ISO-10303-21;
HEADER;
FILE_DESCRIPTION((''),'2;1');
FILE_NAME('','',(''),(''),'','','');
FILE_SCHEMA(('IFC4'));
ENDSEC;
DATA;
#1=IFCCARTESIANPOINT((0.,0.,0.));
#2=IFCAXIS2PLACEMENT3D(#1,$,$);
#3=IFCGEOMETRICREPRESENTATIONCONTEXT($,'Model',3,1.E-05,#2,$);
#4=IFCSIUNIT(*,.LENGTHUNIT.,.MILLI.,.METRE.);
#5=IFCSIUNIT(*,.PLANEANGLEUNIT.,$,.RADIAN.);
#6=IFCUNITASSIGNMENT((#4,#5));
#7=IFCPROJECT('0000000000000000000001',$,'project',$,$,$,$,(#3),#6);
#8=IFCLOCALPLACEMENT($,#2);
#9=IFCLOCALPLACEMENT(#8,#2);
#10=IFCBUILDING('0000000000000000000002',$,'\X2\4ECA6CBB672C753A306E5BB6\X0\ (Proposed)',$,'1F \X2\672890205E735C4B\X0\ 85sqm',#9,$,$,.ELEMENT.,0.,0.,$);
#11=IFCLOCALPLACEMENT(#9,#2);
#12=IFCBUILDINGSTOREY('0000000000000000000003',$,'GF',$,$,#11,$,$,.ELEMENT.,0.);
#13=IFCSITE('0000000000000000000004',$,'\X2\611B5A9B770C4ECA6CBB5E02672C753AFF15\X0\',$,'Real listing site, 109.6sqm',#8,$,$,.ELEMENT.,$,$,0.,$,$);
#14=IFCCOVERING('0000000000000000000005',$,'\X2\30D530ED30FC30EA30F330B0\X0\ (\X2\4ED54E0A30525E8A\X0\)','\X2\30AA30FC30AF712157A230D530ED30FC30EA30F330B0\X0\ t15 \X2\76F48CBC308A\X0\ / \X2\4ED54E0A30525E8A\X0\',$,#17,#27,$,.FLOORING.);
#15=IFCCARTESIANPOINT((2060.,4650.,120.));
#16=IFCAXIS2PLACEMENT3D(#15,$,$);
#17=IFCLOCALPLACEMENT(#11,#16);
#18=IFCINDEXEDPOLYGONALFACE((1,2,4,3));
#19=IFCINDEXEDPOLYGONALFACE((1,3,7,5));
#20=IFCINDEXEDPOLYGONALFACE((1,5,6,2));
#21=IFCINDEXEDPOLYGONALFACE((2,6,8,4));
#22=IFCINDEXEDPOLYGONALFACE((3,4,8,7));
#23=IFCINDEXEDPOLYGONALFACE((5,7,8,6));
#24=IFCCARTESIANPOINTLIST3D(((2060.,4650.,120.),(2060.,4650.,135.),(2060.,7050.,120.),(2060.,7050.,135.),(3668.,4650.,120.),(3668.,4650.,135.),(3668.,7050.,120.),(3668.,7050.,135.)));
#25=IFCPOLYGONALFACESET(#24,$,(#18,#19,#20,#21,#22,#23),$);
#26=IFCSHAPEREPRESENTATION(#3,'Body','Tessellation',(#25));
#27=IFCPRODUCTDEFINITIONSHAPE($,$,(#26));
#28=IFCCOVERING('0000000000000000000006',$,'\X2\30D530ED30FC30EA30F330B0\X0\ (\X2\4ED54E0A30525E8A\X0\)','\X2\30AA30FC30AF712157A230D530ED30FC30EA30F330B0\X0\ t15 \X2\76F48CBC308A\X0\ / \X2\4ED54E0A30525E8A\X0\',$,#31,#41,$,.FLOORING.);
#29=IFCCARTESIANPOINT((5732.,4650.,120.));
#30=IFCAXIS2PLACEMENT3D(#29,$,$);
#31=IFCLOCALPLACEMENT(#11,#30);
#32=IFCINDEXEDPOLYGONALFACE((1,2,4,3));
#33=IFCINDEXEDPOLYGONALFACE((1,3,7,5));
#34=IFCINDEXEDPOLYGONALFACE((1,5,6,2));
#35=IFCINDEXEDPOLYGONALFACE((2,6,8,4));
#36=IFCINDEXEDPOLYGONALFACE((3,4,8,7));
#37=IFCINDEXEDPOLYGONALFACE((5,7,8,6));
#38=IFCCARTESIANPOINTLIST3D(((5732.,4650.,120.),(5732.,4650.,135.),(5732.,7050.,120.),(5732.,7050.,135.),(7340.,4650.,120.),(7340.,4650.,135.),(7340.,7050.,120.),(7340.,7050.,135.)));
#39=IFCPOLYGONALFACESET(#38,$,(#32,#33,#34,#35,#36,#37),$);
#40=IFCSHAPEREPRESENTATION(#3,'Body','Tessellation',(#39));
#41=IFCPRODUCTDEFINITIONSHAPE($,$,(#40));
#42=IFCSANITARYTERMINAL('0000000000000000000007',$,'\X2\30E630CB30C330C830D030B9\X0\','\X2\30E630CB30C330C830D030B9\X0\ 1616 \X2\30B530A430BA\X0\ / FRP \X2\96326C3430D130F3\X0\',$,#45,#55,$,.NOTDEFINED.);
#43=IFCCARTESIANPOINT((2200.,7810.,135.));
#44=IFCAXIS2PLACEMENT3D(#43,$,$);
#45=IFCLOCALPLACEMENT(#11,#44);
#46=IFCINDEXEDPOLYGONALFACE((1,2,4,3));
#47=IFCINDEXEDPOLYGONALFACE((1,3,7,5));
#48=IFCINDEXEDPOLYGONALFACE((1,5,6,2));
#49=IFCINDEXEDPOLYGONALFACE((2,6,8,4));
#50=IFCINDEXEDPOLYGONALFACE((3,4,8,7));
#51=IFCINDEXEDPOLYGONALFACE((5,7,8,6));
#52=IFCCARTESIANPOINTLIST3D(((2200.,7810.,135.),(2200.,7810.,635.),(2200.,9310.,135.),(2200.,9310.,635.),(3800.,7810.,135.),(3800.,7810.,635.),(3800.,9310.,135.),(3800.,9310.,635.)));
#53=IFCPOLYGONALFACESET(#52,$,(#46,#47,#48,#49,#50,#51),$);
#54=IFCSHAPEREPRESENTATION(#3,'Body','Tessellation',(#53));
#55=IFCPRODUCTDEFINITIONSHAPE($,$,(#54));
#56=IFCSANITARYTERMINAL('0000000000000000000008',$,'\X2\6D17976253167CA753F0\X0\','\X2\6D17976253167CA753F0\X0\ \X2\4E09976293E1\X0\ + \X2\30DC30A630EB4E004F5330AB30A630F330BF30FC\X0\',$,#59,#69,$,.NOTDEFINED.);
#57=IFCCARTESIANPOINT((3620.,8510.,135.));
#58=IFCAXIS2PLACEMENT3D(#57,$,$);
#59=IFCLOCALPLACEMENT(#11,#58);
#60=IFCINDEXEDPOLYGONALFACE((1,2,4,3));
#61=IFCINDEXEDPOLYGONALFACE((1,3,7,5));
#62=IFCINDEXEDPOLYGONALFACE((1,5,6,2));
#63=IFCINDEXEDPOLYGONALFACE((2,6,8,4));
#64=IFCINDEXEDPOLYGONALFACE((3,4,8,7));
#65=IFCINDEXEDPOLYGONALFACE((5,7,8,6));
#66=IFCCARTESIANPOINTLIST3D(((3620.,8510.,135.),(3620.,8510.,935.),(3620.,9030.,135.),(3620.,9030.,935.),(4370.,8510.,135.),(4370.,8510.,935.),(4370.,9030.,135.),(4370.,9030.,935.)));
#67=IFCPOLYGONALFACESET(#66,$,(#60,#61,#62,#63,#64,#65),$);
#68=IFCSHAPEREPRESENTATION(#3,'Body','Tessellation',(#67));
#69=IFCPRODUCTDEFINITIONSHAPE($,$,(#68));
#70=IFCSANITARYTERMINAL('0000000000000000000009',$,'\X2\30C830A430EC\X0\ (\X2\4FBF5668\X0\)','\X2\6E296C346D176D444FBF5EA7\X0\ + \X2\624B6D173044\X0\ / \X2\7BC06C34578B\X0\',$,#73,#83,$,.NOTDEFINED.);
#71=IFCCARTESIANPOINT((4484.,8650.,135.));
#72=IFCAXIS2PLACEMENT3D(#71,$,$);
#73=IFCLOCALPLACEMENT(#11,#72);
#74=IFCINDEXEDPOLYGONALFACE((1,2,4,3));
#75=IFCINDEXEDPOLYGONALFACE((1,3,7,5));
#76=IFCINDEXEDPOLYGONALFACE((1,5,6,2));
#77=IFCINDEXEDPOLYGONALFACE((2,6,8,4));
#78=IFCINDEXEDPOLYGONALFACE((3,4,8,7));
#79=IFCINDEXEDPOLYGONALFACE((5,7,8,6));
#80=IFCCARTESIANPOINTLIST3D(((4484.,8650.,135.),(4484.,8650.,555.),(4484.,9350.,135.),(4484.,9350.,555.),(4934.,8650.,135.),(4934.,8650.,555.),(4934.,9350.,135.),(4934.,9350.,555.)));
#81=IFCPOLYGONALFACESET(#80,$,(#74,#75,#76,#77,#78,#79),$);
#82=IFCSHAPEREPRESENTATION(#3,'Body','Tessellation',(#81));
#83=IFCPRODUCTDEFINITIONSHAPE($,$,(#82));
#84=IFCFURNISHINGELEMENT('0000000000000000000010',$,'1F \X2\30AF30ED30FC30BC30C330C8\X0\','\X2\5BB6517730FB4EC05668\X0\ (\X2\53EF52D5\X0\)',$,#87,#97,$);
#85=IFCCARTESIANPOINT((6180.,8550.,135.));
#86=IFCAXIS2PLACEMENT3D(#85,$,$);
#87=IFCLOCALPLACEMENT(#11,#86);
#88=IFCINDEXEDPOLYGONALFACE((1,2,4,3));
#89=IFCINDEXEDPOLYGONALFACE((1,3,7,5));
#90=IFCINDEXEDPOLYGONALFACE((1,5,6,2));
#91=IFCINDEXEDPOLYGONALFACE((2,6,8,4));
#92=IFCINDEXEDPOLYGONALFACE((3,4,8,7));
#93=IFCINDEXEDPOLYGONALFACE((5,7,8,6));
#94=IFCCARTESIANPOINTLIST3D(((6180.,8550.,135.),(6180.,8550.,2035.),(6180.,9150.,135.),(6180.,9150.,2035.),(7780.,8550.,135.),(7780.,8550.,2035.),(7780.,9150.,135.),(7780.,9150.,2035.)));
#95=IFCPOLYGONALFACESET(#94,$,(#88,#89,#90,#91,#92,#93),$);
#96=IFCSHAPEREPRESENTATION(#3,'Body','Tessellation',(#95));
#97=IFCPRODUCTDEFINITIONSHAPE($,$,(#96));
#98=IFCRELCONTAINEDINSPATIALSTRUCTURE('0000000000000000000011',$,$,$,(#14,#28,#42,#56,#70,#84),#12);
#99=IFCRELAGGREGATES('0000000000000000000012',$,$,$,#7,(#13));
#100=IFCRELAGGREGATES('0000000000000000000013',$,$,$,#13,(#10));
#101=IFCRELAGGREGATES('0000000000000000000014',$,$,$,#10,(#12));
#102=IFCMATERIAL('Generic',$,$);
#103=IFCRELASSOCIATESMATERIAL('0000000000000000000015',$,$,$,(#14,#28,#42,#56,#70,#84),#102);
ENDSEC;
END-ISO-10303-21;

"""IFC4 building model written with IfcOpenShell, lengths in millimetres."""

from ifc_helpers import new_model, si_unit, frame, frame_2d, origin, place, context, project, spatial, rectangle, extrude, material, element, save


model = new_model("IFC4")

# Units and contexts
model_context = context("Model", 3, precision=1e-05, world=origin())
ifc_project = project(units=[si_unit("LENGTHUNIT", "METRE", prefix="MILLI"), si_unit("PLANEANGLEUNIT", "RADIAN")], contexts=[model_context])

# Site, building, storey
site_placement = place(None, origin())
site = spatial("IfcSite", under=ifc_project, at=site_placement, Name="愛媛県今治市本町５", ObjectType="Real listing site, 109.6sqm", CompositionType="ELEMENT", RefElevation=0.0)
building_placement = place(site_placement, origin())
building = spatial("IfcBuilding", under=site, at=building_placement, Name="今治本町の家 (Proposed)", ObjectType="1F 木造平屋 85sqm", CompositionType="ELEMENT", ElevationOfRefHeight=0.0, ElevationOfTerrain=0.0)
storey_placement = place(building_placement, origin())
storey = spatial("IfcBuildingStorey", under=building, at=storey_placement, Name="GF", CompositionType="ELEMENT", Elevation=0.0)

# Coverings
ifc_material_1 = material(Name="Generic")
covering_1_placement = place(storey_placement, frame((2060.0, 4650.0, 120.0)))
element("IfcCovering", 1, at=covering_1_placement, inside=storey, material=ifc_material_1, Name="フローリング (仕上げ床)", Description="オーク無垢フローリング t15 直貼り / 仕上げ床", PredefinedType="FLOORING", context=model_context, shape_type="SweptSolid", body=[
    extrude(rectangle(XDim=1608.0, YDim=2400.0, at=frame_2d((804.0, 1200.0))), frame((2060.0, 4650.0, 120.0)), (0.0, 0.0, 1.0), 15.0),
])
covering_2_placement = place(storey_placement, frame((5732.0, 4650.0, 120.0)))
element("IfcCovering", 2, at=covering_2_placement, inside=storey, material=ifc_material_1, Name="フローリング (仕上げ床)", Description="オーク無垢フローリング t15 直貼り / 仕上げ床", PredefinedType="FLOORING", context=model_context, shape_type="SweptSolid", body=[
    extrude(rectangle(XDim=1608.0, YDim=2400.0, at=frame_2d((804.0, 1200.0))), frame((5732.0, 4650.0, 120.0)), (0.0, 0.0, 1.0), 15.0),
])

# Sanitary terminals
sanitary_terminal_1_placement = place(storey_placement, frame((2200.0, 7810.0, 135.0)))
element("IfcSanitaryTerminal", 3, at=sanitary_terminal_1_placement, inside=storey, material=ifc_material_1, Name="ユニットバス", Description="ユニットバス 1616 サイズ / FRP 防水パン", PredefinedType="NOTDEFINED", context=model_context, shape_type="SweptSolid", body=[
    extrude(rectangle(XDim=1600.0, YDim=1500.0, at=frame_2d((800.0, 750.0))), frame((2200.0, 7810.0, 135.0)), (0.0, 0.0, 1.0), 500.0),
])
sanitary_terminal_2_placement = place(storey_placement, frame((3620.0, 8510.0, 135.0)))
element("IfcSanitaryTerminal", 4, at=sanitary_terminal_2_placement, inside=storey, material=ifc_material_1, Name="洗面化粧台", Description="洗面化粧台 三面鏡 + ボウル一体カウンター", PredefinedType="NOTDEFINED", context=model_context, shape_type="SweptSolid", body=[
    extrude(rectangle(XDim=750.0, YDim=520.0, at=frame_2d((375.0, 260.0))), frame((3620.0, 8510.0, 135.0)), (0.0, 0.0, 1.0), 800.0),
])
sanitary_terminal_3_placement = place(storey_placement, frame((4484.0, 8650.0, 135.0)))
element("IfcSanitaryTerminal", 5, at=sanitary_terminal_3_placement, inside=storey, material=ifc_material_1, Name="トイレ (便器)", Description="温水洗浄便座 + 手洗い / 節水型", PredefinedType="NOTDEFINED", context=model_context, shape_type="SweptSolid", body=[
    extrude(rectangle(XDim=450.0, YDim=700.0, at=frame_2d((225.0, 350.0))), frame((4484.0, 8650.0, 135.0)), (0.0, 0.0, 1.0), 420.0),
])

# Furnishing element
furnishing_placement = place(storey_placement, frame((6180.0, 8550.0, 135.0)))
element("IfcFurnishingElement", 6, at=furnishing_placement, inside=storey, material=ifc_material_1, Name="1F クローゼット", Description="家具・什器 (可動)", context=model_context, shape_type="SweptSolid", body=[
    extrude(rectangle(XDim=1600.0, YDim=600.0, at=frame_2d((800.0, 300.0))), frame((6180.0, 8550.0, 135.0)), (0.0, 0.0, 1.0), 1900.0),
])

save(model, "model.ifc")
